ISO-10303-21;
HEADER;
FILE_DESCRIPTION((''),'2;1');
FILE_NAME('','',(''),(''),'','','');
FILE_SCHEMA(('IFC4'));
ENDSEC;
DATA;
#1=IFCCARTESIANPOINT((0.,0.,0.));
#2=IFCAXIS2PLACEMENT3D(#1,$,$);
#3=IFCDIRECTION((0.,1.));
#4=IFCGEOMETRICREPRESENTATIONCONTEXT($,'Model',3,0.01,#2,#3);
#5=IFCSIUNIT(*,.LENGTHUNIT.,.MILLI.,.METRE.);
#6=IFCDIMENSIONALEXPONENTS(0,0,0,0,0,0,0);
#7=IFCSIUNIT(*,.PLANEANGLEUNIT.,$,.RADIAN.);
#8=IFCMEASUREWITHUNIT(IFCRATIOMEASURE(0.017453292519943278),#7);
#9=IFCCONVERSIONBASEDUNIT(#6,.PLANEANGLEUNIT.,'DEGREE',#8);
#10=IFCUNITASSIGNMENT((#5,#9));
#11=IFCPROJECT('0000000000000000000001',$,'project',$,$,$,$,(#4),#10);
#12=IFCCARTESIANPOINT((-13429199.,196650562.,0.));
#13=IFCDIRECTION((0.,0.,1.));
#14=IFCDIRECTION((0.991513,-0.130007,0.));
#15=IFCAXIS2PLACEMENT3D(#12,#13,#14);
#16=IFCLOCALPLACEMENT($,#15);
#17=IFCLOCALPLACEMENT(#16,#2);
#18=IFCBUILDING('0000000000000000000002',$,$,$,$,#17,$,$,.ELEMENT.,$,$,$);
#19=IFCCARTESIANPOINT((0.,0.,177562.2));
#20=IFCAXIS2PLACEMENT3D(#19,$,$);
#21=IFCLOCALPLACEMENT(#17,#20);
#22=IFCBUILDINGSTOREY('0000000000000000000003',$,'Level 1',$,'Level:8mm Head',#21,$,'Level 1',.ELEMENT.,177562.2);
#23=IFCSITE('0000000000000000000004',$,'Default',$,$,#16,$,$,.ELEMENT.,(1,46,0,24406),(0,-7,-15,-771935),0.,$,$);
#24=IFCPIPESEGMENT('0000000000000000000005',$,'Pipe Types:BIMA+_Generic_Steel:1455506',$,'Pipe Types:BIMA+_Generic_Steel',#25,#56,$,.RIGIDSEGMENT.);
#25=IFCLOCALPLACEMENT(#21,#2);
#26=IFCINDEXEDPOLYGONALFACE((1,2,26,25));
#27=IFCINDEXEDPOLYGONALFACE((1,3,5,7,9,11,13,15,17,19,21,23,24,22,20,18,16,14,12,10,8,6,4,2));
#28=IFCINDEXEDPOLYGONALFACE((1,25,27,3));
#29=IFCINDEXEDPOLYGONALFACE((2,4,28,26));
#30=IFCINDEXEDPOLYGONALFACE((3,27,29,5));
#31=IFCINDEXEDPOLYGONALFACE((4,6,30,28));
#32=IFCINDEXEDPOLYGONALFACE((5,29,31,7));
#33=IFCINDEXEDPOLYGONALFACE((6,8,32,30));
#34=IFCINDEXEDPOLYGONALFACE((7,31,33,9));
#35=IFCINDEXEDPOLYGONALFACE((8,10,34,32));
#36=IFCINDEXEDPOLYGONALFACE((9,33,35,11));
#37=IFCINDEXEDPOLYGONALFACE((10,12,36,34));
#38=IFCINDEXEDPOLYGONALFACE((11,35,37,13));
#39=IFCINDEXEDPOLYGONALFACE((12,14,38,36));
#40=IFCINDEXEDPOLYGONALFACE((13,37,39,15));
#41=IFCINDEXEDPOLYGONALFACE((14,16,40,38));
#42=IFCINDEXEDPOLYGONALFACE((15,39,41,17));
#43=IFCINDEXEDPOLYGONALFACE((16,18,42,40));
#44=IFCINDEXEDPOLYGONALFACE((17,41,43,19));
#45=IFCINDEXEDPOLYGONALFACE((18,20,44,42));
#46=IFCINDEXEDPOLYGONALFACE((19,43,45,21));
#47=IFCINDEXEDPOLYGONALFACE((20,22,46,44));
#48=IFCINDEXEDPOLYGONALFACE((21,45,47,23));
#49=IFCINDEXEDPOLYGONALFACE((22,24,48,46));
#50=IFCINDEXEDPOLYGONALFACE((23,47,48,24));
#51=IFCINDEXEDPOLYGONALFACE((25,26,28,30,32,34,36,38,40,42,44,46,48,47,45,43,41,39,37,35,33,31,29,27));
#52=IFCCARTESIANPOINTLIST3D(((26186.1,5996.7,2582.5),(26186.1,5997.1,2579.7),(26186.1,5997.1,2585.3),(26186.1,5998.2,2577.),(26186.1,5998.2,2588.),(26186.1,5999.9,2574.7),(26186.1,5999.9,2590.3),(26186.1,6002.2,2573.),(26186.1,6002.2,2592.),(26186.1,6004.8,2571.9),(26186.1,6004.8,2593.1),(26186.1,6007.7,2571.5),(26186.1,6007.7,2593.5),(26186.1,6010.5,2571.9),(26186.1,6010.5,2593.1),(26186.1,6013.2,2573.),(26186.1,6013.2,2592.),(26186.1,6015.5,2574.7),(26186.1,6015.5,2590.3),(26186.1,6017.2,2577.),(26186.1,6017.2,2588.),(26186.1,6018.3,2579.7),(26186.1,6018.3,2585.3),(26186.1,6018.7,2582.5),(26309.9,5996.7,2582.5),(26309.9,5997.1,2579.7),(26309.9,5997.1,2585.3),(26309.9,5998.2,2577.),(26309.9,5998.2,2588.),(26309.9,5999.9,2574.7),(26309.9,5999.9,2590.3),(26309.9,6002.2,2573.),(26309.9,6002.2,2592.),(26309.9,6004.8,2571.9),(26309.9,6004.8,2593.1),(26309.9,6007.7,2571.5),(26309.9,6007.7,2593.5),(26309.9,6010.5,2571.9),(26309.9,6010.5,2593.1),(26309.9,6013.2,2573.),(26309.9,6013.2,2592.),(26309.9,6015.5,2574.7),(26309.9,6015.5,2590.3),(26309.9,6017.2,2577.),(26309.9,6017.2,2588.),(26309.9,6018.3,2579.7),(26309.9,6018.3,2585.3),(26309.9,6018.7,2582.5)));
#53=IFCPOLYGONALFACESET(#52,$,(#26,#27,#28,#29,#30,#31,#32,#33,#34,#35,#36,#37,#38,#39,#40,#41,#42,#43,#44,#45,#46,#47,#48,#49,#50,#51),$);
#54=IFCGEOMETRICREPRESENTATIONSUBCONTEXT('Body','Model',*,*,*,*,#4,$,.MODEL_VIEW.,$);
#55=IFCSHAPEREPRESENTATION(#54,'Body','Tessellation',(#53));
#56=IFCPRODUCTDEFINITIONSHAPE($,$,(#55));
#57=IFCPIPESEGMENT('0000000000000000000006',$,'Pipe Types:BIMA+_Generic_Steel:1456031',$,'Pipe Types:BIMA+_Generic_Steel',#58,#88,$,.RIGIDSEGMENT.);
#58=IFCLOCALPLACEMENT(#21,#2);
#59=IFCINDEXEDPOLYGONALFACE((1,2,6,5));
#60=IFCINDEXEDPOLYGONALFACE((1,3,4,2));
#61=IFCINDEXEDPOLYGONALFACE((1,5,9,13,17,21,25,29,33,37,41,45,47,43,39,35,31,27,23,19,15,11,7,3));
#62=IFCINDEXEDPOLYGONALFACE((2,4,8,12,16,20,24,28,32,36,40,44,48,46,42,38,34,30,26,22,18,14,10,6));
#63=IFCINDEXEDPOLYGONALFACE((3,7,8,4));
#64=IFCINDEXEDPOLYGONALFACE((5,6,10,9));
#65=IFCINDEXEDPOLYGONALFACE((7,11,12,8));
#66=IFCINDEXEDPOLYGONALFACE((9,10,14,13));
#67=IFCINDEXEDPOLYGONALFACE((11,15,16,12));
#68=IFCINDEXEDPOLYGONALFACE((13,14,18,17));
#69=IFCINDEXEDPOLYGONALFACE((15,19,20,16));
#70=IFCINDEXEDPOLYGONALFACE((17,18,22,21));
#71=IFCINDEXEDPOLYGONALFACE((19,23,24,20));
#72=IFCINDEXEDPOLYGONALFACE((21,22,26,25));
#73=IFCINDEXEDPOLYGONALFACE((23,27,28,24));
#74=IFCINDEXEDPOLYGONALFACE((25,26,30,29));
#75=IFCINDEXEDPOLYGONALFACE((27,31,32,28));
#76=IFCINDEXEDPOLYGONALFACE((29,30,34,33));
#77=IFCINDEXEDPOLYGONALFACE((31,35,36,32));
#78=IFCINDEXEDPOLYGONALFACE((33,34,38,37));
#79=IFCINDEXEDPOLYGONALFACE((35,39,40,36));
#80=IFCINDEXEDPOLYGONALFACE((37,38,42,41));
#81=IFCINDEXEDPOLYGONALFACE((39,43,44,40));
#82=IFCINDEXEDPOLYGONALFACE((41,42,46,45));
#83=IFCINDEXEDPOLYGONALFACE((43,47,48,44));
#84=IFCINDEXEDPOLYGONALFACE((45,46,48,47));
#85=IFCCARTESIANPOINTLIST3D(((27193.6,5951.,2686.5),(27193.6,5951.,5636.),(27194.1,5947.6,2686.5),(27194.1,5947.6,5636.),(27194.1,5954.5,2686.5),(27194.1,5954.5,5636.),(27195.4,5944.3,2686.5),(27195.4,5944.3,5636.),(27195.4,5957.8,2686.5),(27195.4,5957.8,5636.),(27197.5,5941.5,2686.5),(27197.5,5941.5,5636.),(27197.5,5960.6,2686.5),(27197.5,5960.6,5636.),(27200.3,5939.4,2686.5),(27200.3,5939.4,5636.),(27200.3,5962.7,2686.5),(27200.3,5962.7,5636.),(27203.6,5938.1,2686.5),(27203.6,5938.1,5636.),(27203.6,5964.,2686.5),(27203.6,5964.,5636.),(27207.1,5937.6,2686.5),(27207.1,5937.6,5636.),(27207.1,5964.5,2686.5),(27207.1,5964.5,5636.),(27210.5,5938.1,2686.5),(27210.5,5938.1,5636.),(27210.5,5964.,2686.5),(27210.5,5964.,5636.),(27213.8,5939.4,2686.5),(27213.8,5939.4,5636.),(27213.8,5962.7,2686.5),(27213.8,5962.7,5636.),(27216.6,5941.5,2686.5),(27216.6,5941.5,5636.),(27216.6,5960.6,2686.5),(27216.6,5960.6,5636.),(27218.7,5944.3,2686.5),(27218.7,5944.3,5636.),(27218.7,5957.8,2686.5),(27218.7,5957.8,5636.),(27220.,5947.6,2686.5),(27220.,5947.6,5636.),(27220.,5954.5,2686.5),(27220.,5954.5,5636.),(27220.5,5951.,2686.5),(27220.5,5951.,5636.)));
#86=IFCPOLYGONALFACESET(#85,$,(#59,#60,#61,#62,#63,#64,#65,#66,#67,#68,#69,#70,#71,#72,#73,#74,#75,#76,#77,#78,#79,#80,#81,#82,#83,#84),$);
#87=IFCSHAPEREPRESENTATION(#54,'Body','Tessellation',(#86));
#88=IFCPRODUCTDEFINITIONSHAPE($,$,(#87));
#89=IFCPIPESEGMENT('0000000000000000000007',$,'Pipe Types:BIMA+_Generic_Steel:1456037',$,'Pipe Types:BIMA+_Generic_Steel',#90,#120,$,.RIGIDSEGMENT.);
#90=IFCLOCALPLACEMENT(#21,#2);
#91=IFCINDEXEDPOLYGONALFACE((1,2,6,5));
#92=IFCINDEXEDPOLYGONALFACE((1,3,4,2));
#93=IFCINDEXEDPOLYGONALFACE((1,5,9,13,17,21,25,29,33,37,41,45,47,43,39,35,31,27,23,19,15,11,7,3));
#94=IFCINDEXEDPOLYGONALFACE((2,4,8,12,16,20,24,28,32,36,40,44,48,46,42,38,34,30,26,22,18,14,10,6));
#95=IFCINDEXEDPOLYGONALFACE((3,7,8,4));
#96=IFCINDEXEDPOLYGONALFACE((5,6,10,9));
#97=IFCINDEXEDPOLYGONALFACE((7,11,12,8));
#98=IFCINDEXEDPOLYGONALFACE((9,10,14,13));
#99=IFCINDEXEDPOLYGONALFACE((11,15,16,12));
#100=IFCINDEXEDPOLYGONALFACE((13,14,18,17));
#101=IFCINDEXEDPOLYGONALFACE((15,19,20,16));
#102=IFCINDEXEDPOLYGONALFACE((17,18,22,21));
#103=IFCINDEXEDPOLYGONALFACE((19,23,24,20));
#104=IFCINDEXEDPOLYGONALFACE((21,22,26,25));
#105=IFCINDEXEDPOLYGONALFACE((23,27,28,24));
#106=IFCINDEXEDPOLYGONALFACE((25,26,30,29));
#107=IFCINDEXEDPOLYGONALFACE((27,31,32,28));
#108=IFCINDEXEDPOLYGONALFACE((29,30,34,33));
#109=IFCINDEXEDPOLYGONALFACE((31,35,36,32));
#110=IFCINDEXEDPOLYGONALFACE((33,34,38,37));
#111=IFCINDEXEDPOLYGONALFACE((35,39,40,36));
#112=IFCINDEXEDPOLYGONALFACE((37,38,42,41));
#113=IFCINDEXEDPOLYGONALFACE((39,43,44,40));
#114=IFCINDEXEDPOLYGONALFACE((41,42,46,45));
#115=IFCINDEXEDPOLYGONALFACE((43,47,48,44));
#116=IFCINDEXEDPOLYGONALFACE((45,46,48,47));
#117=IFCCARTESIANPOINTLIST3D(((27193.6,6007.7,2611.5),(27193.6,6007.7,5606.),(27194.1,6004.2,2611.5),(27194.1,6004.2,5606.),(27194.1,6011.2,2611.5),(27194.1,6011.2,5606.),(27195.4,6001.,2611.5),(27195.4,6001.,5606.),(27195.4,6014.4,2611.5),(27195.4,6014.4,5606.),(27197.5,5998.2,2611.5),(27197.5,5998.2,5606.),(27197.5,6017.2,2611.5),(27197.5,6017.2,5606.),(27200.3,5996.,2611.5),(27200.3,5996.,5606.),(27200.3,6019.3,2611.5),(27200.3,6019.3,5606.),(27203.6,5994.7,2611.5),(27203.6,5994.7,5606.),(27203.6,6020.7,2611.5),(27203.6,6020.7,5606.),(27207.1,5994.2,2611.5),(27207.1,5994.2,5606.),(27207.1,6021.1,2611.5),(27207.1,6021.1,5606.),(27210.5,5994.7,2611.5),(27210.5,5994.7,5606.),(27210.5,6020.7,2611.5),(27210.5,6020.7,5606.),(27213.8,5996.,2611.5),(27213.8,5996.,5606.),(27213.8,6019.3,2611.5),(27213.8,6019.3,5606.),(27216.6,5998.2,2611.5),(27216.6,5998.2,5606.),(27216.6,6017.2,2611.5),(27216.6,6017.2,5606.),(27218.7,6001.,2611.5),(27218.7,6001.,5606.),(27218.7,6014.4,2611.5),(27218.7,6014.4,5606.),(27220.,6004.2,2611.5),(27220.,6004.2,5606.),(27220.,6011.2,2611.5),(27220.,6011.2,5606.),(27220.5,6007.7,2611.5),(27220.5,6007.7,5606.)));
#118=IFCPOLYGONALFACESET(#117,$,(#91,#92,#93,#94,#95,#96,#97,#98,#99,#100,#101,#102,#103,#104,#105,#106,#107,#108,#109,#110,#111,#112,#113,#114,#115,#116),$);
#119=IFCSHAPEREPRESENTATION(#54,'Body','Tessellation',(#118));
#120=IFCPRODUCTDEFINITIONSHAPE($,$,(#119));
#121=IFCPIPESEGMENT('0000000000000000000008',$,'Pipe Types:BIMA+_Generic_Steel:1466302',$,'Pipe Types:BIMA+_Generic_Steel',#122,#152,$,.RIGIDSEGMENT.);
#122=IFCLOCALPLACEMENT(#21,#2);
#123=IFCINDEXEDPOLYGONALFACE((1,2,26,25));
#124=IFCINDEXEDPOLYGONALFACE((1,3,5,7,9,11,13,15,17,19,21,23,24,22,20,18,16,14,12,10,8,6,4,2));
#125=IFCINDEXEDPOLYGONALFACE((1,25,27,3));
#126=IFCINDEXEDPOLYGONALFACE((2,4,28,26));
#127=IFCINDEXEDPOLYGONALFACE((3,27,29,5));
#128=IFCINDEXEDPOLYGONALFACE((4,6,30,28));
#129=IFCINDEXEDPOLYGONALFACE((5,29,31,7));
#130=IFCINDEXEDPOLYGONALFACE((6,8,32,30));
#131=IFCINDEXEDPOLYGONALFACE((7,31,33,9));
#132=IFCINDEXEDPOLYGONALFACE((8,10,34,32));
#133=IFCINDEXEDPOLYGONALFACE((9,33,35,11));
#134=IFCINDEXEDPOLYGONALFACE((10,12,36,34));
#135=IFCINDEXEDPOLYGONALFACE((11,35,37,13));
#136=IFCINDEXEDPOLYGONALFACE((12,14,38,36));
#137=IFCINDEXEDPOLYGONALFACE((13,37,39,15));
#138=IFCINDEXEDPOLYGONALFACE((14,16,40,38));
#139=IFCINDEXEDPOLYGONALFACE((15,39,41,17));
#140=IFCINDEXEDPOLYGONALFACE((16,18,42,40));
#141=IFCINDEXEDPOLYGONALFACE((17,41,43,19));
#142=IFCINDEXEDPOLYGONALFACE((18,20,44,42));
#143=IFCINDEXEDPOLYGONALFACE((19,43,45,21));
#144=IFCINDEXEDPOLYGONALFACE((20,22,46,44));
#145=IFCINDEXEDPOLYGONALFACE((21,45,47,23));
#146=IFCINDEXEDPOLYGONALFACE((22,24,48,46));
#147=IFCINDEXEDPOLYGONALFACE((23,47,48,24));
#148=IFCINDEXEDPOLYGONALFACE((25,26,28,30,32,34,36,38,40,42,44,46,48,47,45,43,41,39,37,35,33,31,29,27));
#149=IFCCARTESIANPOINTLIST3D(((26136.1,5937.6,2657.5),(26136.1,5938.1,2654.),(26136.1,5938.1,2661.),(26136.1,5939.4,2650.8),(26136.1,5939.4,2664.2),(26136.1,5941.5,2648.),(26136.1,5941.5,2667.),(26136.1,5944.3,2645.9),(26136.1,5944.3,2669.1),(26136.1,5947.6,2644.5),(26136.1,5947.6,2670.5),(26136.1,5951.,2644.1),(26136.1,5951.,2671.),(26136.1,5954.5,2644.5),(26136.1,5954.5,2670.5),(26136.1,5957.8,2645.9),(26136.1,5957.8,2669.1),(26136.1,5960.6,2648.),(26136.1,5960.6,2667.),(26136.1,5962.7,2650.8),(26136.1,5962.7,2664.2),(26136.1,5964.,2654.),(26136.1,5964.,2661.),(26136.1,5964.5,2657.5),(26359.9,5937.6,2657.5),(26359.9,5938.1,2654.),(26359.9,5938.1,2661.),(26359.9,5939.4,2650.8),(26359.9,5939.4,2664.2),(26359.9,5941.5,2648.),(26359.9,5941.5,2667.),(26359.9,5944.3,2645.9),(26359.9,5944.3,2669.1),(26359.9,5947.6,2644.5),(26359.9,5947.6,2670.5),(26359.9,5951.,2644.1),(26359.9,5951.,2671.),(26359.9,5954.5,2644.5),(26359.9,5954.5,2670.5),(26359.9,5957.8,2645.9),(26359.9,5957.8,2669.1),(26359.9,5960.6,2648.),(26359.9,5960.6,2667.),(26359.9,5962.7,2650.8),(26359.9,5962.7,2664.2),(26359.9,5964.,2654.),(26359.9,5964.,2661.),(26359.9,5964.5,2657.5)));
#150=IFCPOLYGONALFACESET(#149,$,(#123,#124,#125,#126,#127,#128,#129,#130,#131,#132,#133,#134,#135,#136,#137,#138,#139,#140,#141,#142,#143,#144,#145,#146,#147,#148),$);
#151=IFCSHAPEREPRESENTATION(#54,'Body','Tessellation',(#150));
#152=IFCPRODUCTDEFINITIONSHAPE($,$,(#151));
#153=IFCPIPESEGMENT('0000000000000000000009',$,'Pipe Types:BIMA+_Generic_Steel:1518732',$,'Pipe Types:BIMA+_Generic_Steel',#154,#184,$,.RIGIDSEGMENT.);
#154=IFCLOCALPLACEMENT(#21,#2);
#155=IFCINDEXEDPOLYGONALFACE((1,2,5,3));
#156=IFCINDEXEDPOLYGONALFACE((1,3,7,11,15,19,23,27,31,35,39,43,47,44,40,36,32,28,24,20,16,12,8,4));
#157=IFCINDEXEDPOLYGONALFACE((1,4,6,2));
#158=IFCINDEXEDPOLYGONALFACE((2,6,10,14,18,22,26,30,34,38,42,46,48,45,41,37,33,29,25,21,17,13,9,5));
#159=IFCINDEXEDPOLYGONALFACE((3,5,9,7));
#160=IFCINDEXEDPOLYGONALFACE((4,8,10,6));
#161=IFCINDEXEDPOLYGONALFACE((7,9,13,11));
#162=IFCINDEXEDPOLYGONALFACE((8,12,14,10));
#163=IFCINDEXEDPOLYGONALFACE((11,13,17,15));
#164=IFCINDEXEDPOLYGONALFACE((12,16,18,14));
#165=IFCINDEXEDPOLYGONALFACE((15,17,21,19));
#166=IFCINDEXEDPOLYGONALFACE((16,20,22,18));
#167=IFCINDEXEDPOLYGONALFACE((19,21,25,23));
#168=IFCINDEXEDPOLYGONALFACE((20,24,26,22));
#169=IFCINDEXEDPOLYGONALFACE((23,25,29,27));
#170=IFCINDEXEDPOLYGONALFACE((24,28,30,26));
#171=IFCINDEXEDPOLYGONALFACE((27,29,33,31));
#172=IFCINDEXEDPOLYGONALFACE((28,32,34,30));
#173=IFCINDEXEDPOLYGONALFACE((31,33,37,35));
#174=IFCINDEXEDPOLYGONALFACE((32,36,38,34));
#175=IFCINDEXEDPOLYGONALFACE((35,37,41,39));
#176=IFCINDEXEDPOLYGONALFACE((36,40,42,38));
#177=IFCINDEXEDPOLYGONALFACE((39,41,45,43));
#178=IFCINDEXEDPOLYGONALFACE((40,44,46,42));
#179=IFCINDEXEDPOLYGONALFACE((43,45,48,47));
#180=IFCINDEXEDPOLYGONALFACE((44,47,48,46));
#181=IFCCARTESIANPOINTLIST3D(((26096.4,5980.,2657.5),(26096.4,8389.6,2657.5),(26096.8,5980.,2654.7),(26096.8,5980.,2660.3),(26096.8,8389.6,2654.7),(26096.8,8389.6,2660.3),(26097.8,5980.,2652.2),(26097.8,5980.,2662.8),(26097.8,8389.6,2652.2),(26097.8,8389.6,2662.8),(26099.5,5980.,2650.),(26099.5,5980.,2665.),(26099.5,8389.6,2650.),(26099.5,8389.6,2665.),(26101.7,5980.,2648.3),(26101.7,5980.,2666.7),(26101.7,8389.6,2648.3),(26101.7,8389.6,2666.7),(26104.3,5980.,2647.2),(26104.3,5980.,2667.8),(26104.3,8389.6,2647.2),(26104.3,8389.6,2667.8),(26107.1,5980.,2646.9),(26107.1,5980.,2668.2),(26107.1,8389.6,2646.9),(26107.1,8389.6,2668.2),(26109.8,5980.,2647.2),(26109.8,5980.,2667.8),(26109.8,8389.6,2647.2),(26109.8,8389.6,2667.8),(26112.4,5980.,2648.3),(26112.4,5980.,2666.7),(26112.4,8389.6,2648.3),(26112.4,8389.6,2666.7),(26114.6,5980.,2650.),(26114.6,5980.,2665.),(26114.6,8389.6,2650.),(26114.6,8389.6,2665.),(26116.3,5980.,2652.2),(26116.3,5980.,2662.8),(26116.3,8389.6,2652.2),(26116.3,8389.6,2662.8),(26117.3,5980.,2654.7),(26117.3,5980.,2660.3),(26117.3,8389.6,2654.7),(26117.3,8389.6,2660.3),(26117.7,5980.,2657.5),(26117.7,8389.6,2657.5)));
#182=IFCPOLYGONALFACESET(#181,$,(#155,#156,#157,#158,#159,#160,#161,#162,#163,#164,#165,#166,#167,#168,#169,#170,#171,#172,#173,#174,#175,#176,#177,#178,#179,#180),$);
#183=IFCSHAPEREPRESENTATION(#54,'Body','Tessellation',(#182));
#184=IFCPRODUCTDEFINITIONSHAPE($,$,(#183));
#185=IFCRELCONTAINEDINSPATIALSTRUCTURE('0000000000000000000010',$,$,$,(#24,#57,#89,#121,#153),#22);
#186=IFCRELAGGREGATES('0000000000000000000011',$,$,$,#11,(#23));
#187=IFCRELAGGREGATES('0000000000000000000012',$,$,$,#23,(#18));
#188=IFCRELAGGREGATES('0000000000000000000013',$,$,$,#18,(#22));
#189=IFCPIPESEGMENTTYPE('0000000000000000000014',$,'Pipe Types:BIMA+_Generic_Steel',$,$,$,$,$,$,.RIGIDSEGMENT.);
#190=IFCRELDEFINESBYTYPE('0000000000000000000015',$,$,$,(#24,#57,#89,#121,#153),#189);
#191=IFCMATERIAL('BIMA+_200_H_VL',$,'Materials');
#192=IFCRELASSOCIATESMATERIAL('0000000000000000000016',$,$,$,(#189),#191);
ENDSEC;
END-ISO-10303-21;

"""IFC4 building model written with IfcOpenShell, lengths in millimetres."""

from ifc_helpers import new_model, entity, si_unit, converted_unit, direction, frame, origin, place, context, subcontext, project, spatial, arc, indexed_curve, outline, extrude, material, type_object, element, save


model = new_model("IFC4")

# Units and contexts
model_context = context("Model", 3, precision=0.01, world=origin(), true_north=direction((0.0, 1.0)))
body_context = subcontext(model_context, "Body", "Model", "MODEL_VIEW")
ifc_project = project(units=[si_unit("LENGTHUNIT", "METRE", prefix="MILLI"), converted_unit("PLANEANGLEUNIT", "DEGREE", entity("IfcRatioMeasure", 0.017453292519943278), si_unit("PLANEANGLEUNIT", "RADIAN"), dimensions=[0, 0, 0, 0, 0, 0, 0])], contexts=[model_context])

# Site, building, storey
site_placement = place(None, frame((-13429199.0, 196650562.0, 0.0), z_axis=(0.0, 0.0, 1.0), x_axis=(0.991513, -0.130007, 0.0)))
site = spatial("IfcSite", under=ifc_project, at=site_placement, Name="Default", CompositionType="ELEMENT", RefLatitude=(1, 46, 0, 24406), RefLongitude=(0, -7, -15, -771935), RefElevation=0.0)
building_placement = place(site_placement, origin())
building = spatial("IfcBuilding", under=site, at=building_placement, CompositionType="ELEMENT")
storey_placement = place(building_placement, frame((0.0, 0.0, 177562.2)))
storey = spatial("IfcBuildingStorey", under=building, at=storey_placement, Name="Level 1", ObjectType="Level:8mm Head", LongName="Level 1", CompositionType="ELEMENT", Elevation=177562.2)

# Pipe segments
ifc_material_1 = material(Name="BIMA+_200_H_VL", Category="Materials")
pipe_segment_type_1 = type_object("IfcPipeSegmentType", Name="Pipe Types:BIMA+_Generic_Steel", PredefinedType="RIGIDSEGMENT", material=ifc_material_1)
pipe_segment_1_placement = place(storey_placement, frame((26186.1, 5995.1, 2595.1)))
element("IfcPipeSegment", 1, at=pipe_segment_1_placement, inside=storey, type_object=pipe_segment_type_1, Name="Pipe Types:BIMA+_Generic_Steel:1455506", ObjectType="Pipe Types:BIMA+_Generic_Steel", PredefinedType="RIGIDSEGMENT", context=body_context, shape_type="SweptSolid", body=[
    extrude(outline(indexed_curve([(11.0, 0.0), (7.8, 7.8), (0.0, 11.0), (-7.8, 7.8), (-11.0, 0.0), (-7.8, -7.8), (0.0, -11.0), (7.8, -7.8)], segments=[arc(1, 2, 3), arc(3, 4, 5), arc(5, 6, 7), arc(7, 8, 1)], self_intersect=False)), frame((0.0, 12.6, -12.6), z_axis=(1.0, 0.0, 0.0), x_axis=(0.0, -1.0, 0.0)), (0.0, 0.0, 1.0), 123.8),
])
pipe_segment_2_placement = place(storey_placement, frame((27192.0, 5936.0, 2686.5)))
element("IfcPipeSegment", 2, at=pipe_segment_2_placement, inside=storey, type_object=pipe_segment_type_1, Name="Pipe Types:BIMA+_Generic_Steel:1456031", ObjectType="Pipe Types:BIMA+_Generic_Steel", PredefinedType="RIGIDSEGMENT", context=body_context, shape_type="SweptSolid", body=[
    extrude(outline(indexed_curve([(13.5, 0.0), (9.5, 9.5), (0.0, 13.5), (-9.5, 9.5), (-13.5, 0.0), (-9.5, -9.5), (0.0, -13.5), (9.5, -9.5)], segments=[arc(1, 2, 3), arc(3, 4, 5), arc(5, 6, 7), arc(7, 8, 1)], self_intersect=False)), frame((15.0, 15.0, 0.0), z_axis=(0.0, 0.0, 1.0), x_axis=(-1.0, 0.0, 0.0)), (0.0, 0.0, 1.0), 2949.5),
])
pipe_segment_3_placement = place(storey_placement, frame((27192.0, 5992.7, 2611.5)))
element("IfcPipeSegment", 3, at=pipe_segment_3_placement, inside=storey, type_object=pipe_segment_type_1, Name="Pipe Types:BIMA+_Generic_Steel:1456037", ObjectType="Pipe Types:BIMA+_Generic_Steel", PredefinedType="RIGIDSEGMENT", context=body_context, shape_type="SweptSolid", body=[
    extrude(outline(indexed_curve([(13.5, 0.0), (9.5, 9.5), (0.0, 13.5), (-9.5, 9.5), (-13.5, 0.0), (-9.5, -9.5), (0.0, -13.5), (9.5, -9.5)], segments=[arc(1, 2, 3), arc(3, 4, 5), arc(5, 6, 7), arc(7, 8, 1)], self_intersect=False)), frame((15.0, 15.0, 0.0), z_axis=(0.0, 0.0, 1.0), x_axis=(-1.0, 0.0, 0.0)), (0.0, 0.0, 1.0), 2994.5),
])
pipe_segment_4_placement = place(storey_placement, frame((26136.1, 5936.0, 2642.5)))
element("IfcPipeSegment", 4, at=pipe_segment_4_placement, inside=storey, type_object=pipe_segment_type_1, Name="Pipe Types:BIMA+_Generic_Steel:1466302", ObjectType="Pipe Types:BIMA+_Generic_Steel", PredefinedType="RIGIDSEGMENT", context=body_context, shape_type="SweptSolid", body=[
    extrude(outline(indexed_curve([(13.5, 0.0), (9.5, 9.5), (0.0, 13.5), (-9.5, 9.5), (-13.5, 0.0), (-9.5, -9.5), (0.0, -13.5), (9.5, -9.5)], segments=[arc(1, 2, 3), arc(3, 4, 5), arc(5, 6, 7), arc(7, 8, 1)], self_intersect=False)), frame((0.0, 15.0, 15.0), z_axis=(1.0, 0.0, 0.0), x_axis=(0.0, 1.0, 0.0)), (0.0, 0.0, 1.0), 223.8),
])
pipe_segment_5_placement = place(storey_placement, frame((26094.8, 5980.0, 2645.3)))
element("IfcPipeSegment", 5, at=pipe_segment_5_placement, inside=storey, type_object=pipe_segment_type_1, Name="Pipe Types:BIMA+_Generic_Steel:1518732", ObjectType="Pipe Types:BIMA+_Generic_Steel", PredefinedType="RIGIDSEGMENT", context=body_context, shape_type="SweptSolid", body=[
    extrude(outline(indexed_curve([(10.7, 0.0), (7.5, 7.5), (0.0, 10.6), (-7.5, 7.5), (-10.7, 0.0), (-7.5, -7.5), (0.0, -10.7), (7.5, -7.5)], segments=[arc(1, 2, 3), arc(3, 4, 5), arc(5, 6, 7), arc(7, 8, 1)], self_intersect=False)), frame((12.2, 0.0, 12.2), z_axis=(0.0, 1.0, 0.0), x_axis=(1.0, 0.0, 0.0)), (0.0, 0.0, 1.0), 2409.6),
])

save(model, "model.ifc")
